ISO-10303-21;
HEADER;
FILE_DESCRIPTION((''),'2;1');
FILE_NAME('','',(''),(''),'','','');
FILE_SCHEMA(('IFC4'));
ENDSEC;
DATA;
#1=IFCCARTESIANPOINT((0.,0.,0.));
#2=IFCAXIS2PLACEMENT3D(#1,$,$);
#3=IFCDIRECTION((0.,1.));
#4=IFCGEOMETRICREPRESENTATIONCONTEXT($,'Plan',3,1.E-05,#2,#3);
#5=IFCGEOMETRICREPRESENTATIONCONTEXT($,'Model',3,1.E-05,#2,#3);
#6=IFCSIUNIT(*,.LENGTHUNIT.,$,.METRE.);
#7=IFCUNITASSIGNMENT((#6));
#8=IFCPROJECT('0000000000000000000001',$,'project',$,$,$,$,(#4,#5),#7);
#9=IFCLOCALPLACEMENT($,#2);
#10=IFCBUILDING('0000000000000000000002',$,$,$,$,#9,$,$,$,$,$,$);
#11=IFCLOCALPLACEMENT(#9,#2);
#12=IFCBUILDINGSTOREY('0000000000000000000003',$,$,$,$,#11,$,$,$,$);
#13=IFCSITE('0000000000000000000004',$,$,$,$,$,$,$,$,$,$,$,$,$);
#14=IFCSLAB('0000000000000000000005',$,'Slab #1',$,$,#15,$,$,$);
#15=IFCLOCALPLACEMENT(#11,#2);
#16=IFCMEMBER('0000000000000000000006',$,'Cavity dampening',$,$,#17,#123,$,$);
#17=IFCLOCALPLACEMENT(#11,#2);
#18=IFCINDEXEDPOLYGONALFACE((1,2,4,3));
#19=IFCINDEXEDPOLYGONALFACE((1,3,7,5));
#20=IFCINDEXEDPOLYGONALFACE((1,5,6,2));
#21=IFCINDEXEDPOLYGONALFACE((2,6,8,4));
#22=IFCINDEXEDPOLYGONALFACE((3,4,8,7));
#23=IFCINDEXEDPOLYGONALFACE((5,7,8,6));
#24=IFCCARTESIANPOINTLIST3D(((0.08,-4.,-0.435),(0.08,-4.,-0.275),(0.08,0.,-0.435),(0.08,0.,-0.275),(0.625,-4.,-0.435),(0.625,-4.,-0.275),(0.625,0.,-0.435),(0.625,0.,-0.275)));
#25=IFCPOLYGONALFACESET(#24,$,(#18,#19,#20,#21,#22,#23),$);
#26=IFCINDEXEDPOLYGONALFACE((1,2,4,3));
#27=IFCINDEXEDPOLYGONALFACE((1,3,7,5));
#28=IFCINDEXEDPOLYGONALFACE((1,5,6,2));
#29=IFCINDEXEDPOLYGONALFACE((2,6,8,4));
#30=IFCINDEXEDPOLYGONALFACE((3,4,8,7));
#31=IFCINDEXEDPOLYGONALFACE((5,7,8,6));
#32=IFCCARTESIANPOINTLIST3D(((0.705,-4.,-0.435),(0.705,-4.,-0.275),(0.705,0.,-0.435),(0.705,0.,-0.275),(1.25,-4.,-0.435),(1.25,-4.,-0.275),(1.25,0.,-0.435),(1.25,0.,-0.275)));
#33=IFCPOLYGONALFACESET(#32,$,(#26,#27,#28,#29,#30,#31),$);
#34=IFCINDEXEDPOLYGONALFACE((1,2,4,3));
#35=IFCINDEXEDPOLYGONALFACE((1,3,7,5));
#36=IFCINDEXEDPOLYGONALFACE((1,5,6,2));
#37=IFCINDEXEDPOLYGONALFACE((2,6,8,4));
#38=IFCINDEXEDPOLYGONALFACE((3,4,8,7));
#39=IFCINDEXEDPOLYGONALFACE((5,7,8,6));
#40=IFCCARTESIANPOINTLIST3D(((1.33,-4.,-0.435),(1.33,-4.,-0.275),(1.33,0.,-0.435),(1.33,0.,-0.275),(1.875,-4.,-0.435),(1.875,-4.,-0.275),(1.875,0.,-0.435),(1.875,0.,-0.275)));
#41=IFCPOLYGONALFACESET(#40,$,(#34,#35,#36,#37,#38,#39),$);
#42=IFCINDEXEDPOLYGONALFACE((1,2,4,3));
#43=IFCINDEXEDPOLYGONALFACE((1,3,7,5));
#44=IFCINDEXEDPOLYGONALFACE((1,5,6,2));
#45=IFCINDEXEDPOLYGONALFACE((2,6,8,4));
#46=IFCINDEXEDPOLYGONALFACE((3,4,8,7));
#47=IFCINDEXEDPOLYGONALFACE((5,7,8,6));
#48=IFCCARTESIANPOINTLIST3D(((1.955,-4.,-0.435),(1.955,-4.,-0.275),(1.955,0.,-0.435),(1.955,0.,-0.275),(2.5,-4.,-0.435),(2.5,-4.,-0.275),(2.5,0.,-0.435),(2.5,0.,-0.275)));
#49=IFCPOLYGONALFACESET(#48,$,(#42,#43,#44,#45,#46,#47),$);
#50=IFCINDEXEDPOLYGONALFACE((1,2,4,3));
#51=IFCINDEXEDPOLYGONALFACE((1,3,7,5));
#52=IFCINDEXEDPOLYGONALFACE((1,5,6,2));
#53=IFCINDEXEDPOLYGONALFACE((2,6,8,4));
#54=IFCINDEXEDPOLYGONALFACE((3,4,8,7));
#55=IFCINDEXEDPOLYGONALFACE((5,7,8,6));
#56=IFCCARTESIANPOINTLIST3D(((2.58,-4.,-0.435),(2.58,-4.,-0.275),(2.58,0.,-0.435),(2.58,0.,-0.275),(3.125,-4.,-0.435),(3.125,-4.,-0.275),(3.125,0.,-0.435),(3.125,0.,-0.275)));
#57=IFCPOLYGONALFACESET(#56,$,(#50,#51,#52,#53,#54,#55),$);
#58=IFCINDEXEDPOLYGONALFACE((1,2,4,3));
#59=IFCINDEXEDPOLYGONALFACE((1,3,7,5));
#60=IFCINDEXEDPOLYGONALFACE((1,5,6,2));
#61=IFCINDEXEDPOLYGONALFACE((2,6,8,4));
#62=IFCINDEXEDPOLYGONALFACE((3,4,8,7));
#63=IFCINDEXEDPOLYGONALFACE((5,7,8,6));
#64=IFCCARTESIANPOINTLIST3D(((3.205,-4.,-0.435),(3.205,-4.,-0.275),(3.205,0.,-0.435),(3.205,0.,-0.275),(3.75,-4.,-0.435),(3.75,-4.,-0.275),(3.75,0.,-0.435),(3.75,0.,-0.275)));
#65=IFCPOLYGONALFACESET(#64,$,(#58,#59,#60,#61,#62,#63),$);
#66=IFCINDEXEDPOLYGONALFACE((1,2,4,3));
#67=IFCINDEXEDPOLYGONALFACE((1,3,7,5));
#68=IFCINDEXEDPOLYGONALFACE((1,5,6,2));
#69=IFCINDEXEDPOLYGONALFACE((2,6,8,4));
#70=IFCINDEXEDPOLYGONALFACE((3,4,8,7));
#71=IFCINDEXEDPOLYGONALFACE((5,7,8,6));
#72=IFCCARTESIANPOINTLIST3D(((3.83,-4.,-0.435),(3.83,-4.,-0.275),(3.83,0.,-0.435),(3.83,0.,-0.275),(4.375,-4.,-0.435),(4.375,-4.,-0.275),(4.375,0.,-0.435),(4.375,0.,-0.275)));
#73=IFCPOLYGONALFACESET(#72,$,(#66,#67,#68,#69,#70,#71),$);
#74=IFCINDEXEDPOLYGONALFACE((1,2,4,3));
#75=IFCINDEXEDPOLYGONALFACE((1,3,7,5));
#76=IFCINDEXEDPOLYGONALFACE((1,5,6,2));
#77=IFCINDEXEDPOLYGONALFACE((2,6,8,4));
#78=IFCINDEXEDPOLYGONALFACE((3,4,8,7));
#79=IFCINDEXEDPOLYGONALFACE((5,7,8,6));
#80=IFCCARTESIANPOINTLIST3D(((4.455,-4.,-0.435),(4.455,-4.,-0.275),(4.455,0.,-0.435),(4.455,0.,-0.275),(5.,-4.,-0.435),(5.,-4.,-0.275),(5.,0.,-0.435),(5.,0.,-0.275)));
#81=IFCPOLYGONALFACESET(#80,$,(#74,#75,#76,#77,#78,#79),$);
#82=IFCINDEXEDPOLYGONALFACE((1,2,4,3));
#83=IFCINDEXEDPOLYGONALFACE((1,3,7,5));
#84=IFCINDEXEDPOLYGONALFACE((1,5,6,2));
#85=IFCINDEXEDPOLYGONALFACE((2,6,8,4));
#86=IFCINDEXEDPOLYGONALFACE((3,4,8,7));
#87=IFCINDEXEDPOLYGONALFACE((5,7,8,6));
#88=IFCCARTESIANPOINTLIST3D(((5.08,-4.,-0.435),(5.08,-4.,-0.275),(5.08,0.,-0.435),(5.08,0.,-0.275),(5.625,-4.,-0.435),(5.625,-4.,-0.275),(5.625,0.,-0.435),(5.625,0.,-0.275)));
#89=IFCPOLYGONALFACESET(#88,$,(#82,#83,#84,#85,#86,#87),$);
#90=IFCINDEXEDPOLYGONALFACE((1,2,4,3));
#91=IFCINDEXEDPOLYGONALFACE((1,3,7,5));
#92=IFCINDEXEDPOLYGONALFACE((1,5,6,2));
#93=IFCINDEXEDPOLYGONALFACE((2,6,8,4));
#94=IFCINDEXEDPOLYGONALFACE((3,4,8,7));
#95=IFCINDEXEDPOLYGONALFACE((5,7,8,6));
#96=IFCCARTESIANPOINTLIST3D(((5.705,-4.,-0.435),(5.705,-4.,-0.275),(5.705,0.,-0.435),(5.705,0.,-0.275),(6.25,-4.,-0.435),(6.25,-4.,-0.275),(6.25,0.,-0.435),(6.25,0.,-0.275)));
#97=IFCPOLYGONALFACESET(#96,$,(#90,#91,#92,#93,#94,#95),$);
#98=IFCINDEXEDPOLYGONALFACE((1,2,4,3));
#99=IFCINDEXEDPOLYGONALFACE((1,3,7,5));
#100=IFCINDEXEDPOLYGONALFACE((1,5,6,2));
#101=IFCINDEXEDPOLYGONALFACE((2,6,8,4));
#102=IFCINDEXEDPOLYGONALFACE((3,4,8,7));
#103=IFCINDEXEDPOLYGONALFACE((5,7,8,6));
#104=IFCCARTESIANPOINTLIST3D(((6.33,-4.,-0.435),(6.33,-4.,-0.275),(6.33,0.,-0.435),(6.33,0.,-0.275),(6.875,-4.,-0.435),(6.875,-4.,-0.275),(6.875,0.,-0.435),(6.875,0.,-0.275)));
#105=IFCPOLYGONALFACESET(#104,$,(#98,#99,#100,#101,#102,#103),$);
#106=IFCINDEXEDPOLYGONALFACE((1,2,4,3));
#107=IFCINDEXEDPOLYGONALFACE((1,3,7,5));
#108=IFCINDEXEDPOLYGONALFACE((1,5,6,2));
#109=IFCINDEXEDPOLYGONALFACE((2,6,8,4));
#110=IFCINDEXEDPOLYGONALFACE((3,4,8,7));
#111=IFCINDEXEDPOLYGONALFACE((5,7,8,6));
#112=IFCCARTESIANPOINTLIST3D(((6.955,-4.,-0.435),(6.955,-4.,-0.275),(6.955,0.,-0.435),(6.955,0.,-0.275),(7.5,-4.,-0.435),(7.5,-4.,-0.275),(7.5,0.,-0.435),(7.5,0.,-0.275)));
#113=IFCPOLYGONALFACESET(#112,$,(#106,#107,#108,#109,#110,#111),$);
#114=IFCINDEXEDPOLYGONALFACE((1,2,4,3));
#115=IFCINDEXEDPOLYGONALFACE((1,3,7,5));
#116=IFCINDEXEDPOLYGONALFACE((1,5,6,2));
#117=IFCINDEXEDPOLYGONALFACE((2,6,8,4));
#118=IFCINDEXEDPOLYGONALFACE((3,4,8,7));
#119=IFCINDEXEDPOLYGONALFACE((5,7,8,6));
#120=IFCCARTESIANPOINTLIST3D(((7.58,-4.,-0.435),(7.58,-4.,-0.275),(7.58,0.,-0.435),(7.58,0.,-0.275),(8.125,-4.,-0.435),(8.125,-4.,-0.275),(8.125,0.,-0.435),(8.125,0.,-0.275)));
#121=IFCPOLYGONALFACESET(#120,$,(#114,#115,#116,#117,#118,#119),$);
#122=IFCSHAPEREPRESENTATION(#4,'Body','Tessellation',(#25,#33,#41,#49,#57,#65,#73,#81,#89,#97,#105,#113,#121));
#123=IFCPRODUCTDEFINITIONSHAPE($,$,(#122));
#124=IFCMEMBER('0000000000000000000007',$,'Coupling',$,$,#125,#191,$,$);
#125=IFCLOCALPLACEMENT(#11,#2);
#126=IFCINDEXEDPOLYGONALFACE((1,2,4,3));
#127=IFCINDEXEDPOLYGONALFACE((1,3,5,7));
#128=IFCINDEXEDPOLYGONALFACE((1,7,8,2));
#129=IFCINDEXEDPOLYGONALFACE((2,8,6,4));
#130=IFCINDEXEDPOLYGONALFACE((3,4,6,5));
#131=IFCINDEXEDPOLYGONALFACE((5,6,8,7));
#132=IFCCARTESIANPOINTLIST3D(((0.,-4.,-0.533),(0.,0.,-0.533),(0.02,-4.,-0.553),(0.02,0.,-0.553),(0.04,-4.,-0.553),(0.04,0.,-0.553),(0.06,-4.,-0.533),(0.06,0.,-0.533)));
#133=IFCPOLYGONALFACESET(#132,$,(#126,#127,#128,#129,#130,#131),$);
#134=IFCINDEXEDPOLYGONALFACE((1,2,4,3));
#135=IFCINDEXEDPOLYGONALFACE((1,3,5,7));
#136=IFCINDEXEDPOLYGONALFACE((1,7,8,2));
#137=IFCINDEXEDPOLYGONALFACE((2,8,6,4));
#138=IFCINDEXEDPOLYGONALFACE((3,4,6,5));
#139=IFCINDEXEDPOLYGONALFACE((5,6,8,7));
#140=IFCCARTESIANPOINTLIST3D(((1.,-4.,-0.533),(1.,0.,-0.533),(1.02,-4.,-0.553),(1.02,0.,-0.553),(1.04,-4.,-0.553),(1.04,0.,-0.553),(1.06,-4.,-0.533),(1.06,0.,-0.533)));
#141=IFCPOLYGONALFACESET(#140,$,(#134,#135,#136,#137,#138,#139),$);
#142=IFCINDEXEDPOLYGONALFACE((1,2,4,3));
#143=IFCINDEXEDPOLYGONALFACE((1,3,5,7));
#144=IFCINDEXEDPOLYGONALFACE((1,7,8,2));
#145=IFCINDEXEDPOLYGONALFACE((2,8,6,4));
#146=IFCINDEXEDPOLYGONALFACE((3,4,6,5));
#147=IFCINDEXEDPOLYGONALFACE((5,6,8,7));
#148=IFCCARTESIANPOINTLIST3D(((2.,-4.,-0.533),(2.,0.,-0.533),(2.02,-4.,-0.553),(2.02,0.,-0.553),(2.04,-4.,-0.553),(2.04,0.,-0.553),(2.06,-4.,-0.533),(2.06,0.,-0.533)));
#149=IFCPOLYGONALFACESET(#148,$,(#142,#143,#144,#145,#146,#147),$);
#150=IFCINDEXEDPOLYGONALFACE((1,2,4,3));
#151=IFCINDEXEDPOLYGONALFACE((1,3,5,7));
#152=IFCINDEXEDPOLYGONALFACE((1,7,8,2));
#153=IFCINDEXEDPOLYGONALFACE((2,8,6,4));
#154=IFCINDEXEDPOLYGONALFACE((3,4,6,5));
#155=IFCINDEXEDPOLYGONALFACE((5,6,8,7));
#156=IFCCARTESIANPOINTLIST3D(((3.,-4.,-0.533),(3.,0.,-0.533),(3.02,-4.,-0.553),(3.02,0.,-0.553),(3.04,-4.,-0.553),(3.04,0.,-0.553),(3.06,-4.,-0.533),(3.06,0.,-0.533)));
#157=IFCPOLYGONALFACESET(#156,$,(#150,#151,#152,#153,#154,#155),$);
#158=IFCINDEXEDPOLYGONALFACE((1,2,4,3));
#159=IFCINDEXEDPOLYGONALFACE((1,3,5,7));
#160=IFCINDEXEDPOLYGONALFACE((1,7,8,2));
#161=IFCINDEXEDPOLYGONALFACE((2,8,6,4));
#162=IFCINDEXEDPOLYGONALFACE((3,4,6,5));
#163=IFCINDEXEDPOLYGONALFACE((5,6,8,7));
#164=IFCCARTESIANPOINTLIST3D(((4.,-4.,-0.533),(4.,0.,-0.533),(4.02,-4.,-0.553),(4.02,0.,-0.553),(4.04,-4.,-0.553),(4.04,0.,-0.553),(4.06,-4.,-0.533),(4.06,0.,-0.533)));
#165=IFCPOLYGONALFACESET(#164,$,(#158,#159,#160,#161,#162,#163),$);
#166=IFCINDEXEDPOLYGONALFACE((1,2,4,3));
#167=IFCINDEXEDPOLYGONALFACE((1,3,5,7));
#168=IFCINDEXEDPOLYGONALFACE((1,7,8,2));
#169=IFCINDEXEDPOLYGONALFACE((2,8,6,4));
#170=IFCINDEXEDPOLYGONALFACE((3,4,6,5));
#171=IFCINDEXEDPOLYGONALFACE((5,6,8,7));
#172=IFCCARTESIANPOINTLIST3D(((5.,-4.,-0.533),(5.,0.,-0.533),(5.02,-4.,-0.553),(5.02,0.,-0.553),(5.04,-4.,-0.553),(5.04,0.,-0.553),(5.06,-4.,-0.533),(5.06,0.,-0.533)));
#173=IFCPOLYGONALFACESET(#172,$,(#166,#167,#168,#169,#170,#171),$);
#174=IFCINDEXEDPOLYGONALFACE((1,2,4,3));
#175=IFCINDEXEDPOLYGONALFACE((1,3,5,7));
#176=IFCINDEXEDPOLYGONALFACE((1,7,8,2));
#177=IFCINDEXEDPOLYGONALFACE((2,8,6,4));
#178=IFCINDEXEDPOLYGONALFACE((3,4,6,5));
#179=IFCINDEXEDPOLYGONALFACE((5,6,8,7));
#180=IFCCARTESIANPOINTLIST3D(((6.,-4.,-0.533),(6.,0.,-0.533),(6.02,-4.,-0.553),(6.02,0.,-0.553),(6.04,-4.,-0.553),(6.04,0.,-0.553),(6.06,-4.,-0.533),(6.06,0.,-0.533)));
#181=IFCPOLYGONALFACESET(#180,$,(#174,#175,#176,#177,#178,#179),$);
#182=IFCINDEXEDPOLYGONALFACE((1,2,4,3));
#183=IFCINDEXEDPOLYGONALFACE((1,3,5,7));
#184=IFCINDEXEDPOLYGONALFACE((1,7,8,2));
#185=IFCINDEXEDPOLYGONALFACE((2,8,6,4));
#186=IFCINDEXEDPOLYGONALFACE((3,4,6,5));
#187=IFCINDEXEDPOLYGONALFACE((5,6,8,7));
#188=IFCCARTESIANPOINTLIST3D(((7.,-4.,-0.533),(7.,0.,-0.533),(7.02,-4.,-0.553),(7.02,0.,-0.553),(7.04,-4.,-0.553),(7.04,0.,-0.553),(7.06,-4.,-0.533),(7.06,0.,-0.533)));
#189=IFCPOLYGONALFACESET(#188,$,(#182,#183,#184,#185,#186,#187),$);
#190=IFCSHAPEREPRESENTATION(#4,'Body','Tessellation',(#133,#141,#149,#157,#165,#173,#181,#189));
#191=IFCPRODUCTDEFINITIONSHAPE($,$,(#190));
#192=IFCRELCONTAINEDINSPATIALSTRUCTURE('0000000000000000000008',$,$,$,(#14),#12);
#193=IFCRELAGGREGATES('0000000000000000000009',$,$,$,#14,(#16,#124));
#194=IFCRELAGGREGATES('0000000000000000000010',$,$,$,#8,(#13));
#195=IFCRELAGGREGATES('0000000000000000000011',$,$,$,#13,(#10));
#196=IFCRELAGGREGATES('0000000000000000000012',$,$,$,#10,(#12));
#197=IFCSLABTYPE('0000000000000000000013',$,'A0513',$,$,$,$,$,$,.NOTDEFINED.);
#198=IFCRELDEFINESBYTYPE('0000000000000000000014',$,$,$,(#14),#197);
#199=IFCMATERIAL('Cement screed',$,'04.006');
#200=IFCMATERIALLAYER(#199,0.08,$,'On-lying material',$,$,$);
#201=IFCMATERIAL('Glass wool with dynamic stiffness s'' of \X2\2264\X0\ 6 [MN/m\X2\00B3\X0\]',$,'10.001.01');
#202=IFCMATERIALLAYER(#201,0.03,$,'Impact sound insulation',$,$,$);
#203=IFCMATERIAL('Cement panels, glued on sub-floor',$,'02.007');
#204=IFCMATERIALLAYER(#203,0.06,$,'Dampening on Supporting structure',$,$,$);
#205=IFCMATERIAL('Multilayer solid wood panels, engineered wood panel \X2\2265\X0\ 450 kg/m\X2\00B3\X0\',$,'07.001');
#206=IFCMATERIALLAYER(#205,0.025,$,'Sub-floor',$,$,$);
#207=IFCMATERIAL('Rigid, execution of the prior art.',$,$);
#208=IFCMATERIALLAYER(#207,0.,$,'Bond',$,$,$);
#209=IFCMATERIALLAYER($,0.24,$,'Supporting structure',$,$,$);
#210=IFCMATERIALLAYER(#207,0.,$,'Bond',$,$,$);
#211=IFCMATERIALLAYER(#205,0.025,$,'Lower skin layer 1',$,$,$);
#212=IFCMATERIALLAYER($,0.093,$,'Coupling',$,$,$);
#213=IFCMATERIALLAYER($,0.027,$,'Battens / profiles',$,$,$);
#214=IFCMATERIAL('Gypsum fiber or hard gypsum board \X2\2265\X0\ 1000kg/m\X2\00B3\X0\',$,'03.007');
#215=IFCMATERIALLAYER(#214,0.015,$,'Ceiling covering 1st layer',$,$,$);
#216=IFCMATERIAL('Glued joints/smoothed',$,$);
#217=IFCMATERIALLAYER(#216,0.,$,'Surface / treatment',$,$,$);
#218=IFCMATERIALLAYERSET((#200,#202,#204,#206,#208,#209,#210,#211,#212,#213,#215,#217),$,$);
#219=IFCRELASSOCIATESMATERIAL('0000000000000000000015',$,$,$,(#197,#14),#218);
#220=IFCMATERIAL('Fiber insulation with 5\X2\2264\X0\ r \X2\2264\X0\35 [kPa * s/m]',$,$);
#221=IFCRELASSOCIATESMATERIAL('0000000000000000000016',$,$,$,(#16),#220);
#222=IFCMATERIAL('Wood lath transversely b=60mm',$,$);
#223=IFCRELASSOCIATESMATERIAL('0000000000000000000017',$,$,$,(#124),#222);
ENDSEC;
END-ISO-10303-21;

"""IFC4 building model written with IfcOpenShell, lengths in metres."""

from ifc_helpers import new_model, si_unit, direction, frame, frame_2d, origin, place, context, project, spatial, polyline, rectangle, outline, extrude, material, layer, layer_set, type_object, element, aggregate, save


model = new_model("IFC4")

# Units and contexts
plan_context = context("Plan", 3, precision=1e-05, world=origin(), true_north=direction((0.0, 1.0)))
model_context = context("Model", 3, precision=1e-05, world=origin(), true_north=direction((0.0, 1.0)))
ifc_project = project(units=[si_unit("LENGTHUNIT", "METRE")], contexts=[plan_context, model_context])

# Site, building, storey
site = spatial("IfcSite", under=ifc_project)
building_placement = place(None, origin())
building = spatial("IfcBuilding", under=site, at=building_placement)
storey_placement = place(building_placement, origin())
storey = spatial("IfcBuildingStorey", under=building, at=storey_placement)

# Slab, members
ifc_material_1 = material(Name="Cement screed", Category="04.006")
ifc_layer_1 = layer(ifc_material_1, 0.08, Name="On-lying material")
ifc_material_2 = material(Name="Glass wool with dynamic stiffness s' of ≤ 6 [MN/m³]", Category="10.001.01")
ifc_layer_2 = layer(ifc_material_2, 0.03, Name="Impact sound insulation")
ifc_material_3 = material(Name="Cement panels, glued on sub-floor", Category="02.007")
ifc_layer_3 = layer(ifc_material_3, 0.06, Name="Dampening on Supporting structure")
ifc_material_4 = material(Name="Multilayer solid wood panels, engineered wood panel ≥ 450 kg/m³", Category="07.001")
ifc_layer_4 = layer(ifc_material_4, 0.025, Name="Sub-floor")
ifc_material_5 = material(Name="Rigid, execution of the prior art.")
ifc_layer_5 = layer(ifc_material_5, 0.0, Name="Bond")
ifc_layer_6 = layer(None, 0.24, Name="Supporting structure")
ifc_layer_7 = layer(ifc_material_5, 0.0, Name="Bond")
ifc_layer_8 = layer(ifc_material_4, 0.025, Name="Lower skin layer 1")
ifc_layer_9 = layer(None, 0.093, Name="Coupling")
ifc_layer_10 = layer(None, 0.027, Name="Battens / profiles")
ifc_material_6 = material(Name="Gypsum fiber or hard gypsum board ≥ 1000kg/m³", Category="03.007")
ifc_layer_11 = layer(ifc_material_6, 0.015, Name="Ceiling covering 1st layer")
ifc_material_7 = material(Name="Glued joints/smoothed")
ifc_layer_12 = layer(ifc_material_7, 0.0, Name="Surface / treatment")
ifc_layer_set = layer_set([ifc_layer_1, ifc_layer_2, ifc_layer_3, ifc_layer_4, ifc_layer_5, ifc_layer_6, ifc_layer_7, ifc_layer_8, ifc_layer_9, ifc_layer_10, ifc_layer_11, ifc_layer_12])
slab_type = type_object("IfcSlabType", Name="A0513", PredefinedType="NOTDEFINED", material=ifc_layer_set)
slab_placement = place(None, frame((0.0, 0.0, 0.0), z_axis=(0.0, 0.0, -1.0), x_axis=(1.0, 0.0, 0.0)))
slab = element("IfcSlab", 1, at=slab_placement, inside=storey, type_object=slab_type, material=ifc_layer_set, Name="Slab #1")
ifc_material_8 = material(Name="Fiber insulation with 5≤ r ≤35 [kPa * s/m]")
member_1_placement = place(slab_placement, origin())
member_1 = element("IfcMember", 2, at=member_1_placement, material=ifc_material_8, Name="Cavity dampening", context=plan_context, shape_type="SweptSolid", body=[
    extrude(rectangle(XDim=0.545, YDim=0.16, at=frame_2d((0.2725, 0.08), x_axis=(1.0, 0.0))), frame((0.08, 4.0, 0.275), z_axis=(0.0, -1.0, 0.0), x_axis=(1.0, 0.0, 0.0)), (0.0, 0.0, 1.0), 4.0),
    extrude(rectangle(XDim=0.545, YDim=0.16, at=frame_2d((0.2725, 0.08), x_axis=(1.0, 0.0))), frame((0.705, 4.0, 0.275), z_axis=(0.0, -1.0, 0.0), x_axis=(1.0, 0.0, 0.0)), (0.0, 0.0, 1.0), 4.0),
    extrude(rectangle(XDim=0.545, YDim=0.16, at=frame_2d((0.2725, 0.08), x_axis=(1.0, 0.0))), frame((1.33, 4.0, 0.275), z_axis=(0.0, -1.0, 0.0), x_axis=(1.0, 0.0, 0.0)), (0.0, 0.0, 1.0), 4.0),
    extrude(rectangle(XDim=0.545, YDim=0.16, at=frame_2d((0.2725, 0.08), x_axis=(1.0, 0.0))), frame((1.955, 4.0, 0.275), z_axis=(0.0, -1.0, 0.0), x_axis=(1.0, 0.0, 0.0)), (0.0, 0.0, 1.0), 4.0),
    extrude(rectangle(XDim=0.545, YDim=0.16, at=frame_2d((0.2725, 0.08), x_axis=(1.0, 0.0))), frame((2.58, 4.0, 0.275), z_axis=(0.0, -1.0, 0.0), x_axis=(1.0, 0.0, 0.0)), (0.0, 0.0, 1.0), 4.0),
    extrude(rectangle(XDim=0.545, YDim=0.16, at=frame_2d((0.2725, 0.08), x_axis=(1.0, 0.0))), frame((3.205, 4.0, 0.275), z_axis=(0.0, -1.0, 0.0), x_axis=(1.0, 0.0, 0.0)), (0.0, 0.0, 1.0), 4.0),
    extrude(rectangle(XDim=0.545, YDim=0.16, at=frame_2d((0.2725, 0.08), x_axis=(1.0, 0.0))), frame((3.83, 4.0, 0.275), z_axis=(0.0, -1.0, 0.0), x_axis=(1.0, 0.0, 0.0)), (0.0, 0.0, 1.0), 4.0),
    extrude(rectangle(XDim=0.545, YDim=0.16, at=frame_2d((0.2725, 0.08), x_axis=(1.0, 0.0))), frame((4.455, 4.0, 0.275), z_axis=(0.0, -1.0, 0.0), x_axis=(1.0, 0.0, 0.0)), (0.0, 0.0, 1.0), 4.0),
    extrude(rectangle(XDim=0.545, YDim=0.16, at=frame_2d((0.2725, 0.08), x_axis=(1.0, 0.0))), frame((5.08, 4.0, 0.275), z_axis=(0.0, -1.0, 0.0), x_axis=(1.0, 0.0, 0.0)), (0.0, 0.0, 1.0), 4.0),
    extrude(rectangle(XDim=0.545, YDim=0.16, at=frame_2d((0.2725, 0.08), x_axis=(1.0, 0.0))), frame((5.705, 4.0, 0.275), z_axis=(0.0, -1.0, 0.0), x_axis=(1.0, 0.0, 0.0)), (0.0, 0.0, 1.0), 4.0),
    extrude(rectangle(XDim=0.545, YDim=0.16, at=frame_2d((0.2725, 0.08), x_axis=(1.0, 0.0))), frame((6.33, 4.0, 0.275), z_axis=(0.0, -1.0, 0.0), x_axis=(1.0, 0.0, 0.0)), (0.0, 0.0, 1.0), 4.0),
    extrude(rectangle(XDim=0.545, YDim=0.16, at=frame_2d((0.2725, 0.08), x_axis=(1.0, 0.0))), frame((6.955, 4.0, 0.275), z_axis=(0.0, -1.0, 0.0), x_axis=(1.0, 0.0, 0.0)), (0.0, 0.0, 1.0), 4.0),
    extrude(rectangle(XDim=0.545, YDim=0.16, at=frame_2d((0.2725, 0.08), x_axis=(1.0, 0.0))), frame((7.58, 4.0, 0.275), z_axis=(0.0, -1.0, 0.0), x_axis=(1.0, 0.0, 0.0)), (0.0, 0.0, 1.0), 4.0),
])
ifc_material_9 = material(Name="Wood lath transversely b=60mm")
member_2_placement = place(slab_placement, origin())
member_2 = element("IfcMember", 3, at=member_2_placement, material=ifc_material_9, Name="Coupling", context=plan_context, shape_type="SweptSolid", body=[
    extrude(outline(polyline([(0.0, 0.0), (0.06, 0.0), (0.04, 0.02), (0.02, 0.02), (0.0, 0.0)])), frame((0.0, 4.0, 0.533), z_axis=(0.0, -1.0, 0.0), x_axis=(1.0, 0.0, 0.0)), (0.0, 0.0, 1.0), 4.0),
    extrude(outline(polyline([(0.0, 0.0), (0.06, 0.0), (0.04, 0.02), (0.02, 0.02), (0.0, 0.0)])), frame((1.0, 4.0, 0.533), z_axis=(0.0, -1.0, 0.0), x_axis=(1.0, 0.0, 0.0)), (0.0, 0.0, 1.0), 4.0),
    extrude(outline(polyline([(0.0, 0.0), (0.06, 0.0), (0.04, 0.02), (0.02, 0.02), (0.0, 0.0)])), frame((2.0, 4.0, 0.533), z_axis=(0.0, -1.0, 0.0), x_axis=(1.0, 0.0, 0.0)), (0.0, 0.0, 1.0), 4.0),
    extrude(outline(polyline([(0.0, 0.0), (0.06, 0.0), (0.04, 0.02), (0.02, 0.02), (0.0, 0.0)])), frame((3.0, 4.0, 0.533), z_axis=(0.0, -1.0, 0.0), x_axis=(1.0, 0.0, 0.0)), (0.0, 0.0, 1.0), 4.0),
    extrude(outline(polyline([(0.0, 0.0), (0.06, 0.0), (0.04, 0.02), (0.02, 0.02), (0.0, 0.0)])), frame((4.0, 4.0, 0.533), z_axis=(0.0, -1.0, 0.0), x_axis=(1.0, 0.0, 0.0)), (0.0, 0.0, 1.0), 4.0),
    extrude(outline(polyline([(0.0, 0.0), (0.06, 0.0), (0.04, 0.02), (0.02, 0.02), (0.0, 0.0)])), frame((5.0, 4.0, 0.533), z_axis=(0.0, -1.0, 0.0), x_axis=(1.0, 0.0, 0.0)), (0.0, 0.0, 1.0), 4.0),
    extrude(outline(polyline([(0.0, 0.0), (0.06, 0.0), (0.04, 0.02), (0.02, 0.02), (0.0, 0.0)])), frame((6.0, 4.0, 0.533), z_axis=(0.0, -1.0, 0.0), x_axis=(1.0, 0.0, 0.0)), (0.0, 0.0, 1.0), 4.0),
    extrude(outline(polyline([(0.0, 0.0), (0.06, 0.0), (0.04, 0.02), (0.02, 0.02), (0.0, 0.0)])), frame((7.0, 4.0, 0.533), z_axis=(0.0, -1.0, 0.0), x_axis=(1.0, 0.0, 0.0)), (0.0, 0.0, 1.0), 4.0),
])
aggregate(slab, [member_1, member_2])

save(model, "model.ifc")
